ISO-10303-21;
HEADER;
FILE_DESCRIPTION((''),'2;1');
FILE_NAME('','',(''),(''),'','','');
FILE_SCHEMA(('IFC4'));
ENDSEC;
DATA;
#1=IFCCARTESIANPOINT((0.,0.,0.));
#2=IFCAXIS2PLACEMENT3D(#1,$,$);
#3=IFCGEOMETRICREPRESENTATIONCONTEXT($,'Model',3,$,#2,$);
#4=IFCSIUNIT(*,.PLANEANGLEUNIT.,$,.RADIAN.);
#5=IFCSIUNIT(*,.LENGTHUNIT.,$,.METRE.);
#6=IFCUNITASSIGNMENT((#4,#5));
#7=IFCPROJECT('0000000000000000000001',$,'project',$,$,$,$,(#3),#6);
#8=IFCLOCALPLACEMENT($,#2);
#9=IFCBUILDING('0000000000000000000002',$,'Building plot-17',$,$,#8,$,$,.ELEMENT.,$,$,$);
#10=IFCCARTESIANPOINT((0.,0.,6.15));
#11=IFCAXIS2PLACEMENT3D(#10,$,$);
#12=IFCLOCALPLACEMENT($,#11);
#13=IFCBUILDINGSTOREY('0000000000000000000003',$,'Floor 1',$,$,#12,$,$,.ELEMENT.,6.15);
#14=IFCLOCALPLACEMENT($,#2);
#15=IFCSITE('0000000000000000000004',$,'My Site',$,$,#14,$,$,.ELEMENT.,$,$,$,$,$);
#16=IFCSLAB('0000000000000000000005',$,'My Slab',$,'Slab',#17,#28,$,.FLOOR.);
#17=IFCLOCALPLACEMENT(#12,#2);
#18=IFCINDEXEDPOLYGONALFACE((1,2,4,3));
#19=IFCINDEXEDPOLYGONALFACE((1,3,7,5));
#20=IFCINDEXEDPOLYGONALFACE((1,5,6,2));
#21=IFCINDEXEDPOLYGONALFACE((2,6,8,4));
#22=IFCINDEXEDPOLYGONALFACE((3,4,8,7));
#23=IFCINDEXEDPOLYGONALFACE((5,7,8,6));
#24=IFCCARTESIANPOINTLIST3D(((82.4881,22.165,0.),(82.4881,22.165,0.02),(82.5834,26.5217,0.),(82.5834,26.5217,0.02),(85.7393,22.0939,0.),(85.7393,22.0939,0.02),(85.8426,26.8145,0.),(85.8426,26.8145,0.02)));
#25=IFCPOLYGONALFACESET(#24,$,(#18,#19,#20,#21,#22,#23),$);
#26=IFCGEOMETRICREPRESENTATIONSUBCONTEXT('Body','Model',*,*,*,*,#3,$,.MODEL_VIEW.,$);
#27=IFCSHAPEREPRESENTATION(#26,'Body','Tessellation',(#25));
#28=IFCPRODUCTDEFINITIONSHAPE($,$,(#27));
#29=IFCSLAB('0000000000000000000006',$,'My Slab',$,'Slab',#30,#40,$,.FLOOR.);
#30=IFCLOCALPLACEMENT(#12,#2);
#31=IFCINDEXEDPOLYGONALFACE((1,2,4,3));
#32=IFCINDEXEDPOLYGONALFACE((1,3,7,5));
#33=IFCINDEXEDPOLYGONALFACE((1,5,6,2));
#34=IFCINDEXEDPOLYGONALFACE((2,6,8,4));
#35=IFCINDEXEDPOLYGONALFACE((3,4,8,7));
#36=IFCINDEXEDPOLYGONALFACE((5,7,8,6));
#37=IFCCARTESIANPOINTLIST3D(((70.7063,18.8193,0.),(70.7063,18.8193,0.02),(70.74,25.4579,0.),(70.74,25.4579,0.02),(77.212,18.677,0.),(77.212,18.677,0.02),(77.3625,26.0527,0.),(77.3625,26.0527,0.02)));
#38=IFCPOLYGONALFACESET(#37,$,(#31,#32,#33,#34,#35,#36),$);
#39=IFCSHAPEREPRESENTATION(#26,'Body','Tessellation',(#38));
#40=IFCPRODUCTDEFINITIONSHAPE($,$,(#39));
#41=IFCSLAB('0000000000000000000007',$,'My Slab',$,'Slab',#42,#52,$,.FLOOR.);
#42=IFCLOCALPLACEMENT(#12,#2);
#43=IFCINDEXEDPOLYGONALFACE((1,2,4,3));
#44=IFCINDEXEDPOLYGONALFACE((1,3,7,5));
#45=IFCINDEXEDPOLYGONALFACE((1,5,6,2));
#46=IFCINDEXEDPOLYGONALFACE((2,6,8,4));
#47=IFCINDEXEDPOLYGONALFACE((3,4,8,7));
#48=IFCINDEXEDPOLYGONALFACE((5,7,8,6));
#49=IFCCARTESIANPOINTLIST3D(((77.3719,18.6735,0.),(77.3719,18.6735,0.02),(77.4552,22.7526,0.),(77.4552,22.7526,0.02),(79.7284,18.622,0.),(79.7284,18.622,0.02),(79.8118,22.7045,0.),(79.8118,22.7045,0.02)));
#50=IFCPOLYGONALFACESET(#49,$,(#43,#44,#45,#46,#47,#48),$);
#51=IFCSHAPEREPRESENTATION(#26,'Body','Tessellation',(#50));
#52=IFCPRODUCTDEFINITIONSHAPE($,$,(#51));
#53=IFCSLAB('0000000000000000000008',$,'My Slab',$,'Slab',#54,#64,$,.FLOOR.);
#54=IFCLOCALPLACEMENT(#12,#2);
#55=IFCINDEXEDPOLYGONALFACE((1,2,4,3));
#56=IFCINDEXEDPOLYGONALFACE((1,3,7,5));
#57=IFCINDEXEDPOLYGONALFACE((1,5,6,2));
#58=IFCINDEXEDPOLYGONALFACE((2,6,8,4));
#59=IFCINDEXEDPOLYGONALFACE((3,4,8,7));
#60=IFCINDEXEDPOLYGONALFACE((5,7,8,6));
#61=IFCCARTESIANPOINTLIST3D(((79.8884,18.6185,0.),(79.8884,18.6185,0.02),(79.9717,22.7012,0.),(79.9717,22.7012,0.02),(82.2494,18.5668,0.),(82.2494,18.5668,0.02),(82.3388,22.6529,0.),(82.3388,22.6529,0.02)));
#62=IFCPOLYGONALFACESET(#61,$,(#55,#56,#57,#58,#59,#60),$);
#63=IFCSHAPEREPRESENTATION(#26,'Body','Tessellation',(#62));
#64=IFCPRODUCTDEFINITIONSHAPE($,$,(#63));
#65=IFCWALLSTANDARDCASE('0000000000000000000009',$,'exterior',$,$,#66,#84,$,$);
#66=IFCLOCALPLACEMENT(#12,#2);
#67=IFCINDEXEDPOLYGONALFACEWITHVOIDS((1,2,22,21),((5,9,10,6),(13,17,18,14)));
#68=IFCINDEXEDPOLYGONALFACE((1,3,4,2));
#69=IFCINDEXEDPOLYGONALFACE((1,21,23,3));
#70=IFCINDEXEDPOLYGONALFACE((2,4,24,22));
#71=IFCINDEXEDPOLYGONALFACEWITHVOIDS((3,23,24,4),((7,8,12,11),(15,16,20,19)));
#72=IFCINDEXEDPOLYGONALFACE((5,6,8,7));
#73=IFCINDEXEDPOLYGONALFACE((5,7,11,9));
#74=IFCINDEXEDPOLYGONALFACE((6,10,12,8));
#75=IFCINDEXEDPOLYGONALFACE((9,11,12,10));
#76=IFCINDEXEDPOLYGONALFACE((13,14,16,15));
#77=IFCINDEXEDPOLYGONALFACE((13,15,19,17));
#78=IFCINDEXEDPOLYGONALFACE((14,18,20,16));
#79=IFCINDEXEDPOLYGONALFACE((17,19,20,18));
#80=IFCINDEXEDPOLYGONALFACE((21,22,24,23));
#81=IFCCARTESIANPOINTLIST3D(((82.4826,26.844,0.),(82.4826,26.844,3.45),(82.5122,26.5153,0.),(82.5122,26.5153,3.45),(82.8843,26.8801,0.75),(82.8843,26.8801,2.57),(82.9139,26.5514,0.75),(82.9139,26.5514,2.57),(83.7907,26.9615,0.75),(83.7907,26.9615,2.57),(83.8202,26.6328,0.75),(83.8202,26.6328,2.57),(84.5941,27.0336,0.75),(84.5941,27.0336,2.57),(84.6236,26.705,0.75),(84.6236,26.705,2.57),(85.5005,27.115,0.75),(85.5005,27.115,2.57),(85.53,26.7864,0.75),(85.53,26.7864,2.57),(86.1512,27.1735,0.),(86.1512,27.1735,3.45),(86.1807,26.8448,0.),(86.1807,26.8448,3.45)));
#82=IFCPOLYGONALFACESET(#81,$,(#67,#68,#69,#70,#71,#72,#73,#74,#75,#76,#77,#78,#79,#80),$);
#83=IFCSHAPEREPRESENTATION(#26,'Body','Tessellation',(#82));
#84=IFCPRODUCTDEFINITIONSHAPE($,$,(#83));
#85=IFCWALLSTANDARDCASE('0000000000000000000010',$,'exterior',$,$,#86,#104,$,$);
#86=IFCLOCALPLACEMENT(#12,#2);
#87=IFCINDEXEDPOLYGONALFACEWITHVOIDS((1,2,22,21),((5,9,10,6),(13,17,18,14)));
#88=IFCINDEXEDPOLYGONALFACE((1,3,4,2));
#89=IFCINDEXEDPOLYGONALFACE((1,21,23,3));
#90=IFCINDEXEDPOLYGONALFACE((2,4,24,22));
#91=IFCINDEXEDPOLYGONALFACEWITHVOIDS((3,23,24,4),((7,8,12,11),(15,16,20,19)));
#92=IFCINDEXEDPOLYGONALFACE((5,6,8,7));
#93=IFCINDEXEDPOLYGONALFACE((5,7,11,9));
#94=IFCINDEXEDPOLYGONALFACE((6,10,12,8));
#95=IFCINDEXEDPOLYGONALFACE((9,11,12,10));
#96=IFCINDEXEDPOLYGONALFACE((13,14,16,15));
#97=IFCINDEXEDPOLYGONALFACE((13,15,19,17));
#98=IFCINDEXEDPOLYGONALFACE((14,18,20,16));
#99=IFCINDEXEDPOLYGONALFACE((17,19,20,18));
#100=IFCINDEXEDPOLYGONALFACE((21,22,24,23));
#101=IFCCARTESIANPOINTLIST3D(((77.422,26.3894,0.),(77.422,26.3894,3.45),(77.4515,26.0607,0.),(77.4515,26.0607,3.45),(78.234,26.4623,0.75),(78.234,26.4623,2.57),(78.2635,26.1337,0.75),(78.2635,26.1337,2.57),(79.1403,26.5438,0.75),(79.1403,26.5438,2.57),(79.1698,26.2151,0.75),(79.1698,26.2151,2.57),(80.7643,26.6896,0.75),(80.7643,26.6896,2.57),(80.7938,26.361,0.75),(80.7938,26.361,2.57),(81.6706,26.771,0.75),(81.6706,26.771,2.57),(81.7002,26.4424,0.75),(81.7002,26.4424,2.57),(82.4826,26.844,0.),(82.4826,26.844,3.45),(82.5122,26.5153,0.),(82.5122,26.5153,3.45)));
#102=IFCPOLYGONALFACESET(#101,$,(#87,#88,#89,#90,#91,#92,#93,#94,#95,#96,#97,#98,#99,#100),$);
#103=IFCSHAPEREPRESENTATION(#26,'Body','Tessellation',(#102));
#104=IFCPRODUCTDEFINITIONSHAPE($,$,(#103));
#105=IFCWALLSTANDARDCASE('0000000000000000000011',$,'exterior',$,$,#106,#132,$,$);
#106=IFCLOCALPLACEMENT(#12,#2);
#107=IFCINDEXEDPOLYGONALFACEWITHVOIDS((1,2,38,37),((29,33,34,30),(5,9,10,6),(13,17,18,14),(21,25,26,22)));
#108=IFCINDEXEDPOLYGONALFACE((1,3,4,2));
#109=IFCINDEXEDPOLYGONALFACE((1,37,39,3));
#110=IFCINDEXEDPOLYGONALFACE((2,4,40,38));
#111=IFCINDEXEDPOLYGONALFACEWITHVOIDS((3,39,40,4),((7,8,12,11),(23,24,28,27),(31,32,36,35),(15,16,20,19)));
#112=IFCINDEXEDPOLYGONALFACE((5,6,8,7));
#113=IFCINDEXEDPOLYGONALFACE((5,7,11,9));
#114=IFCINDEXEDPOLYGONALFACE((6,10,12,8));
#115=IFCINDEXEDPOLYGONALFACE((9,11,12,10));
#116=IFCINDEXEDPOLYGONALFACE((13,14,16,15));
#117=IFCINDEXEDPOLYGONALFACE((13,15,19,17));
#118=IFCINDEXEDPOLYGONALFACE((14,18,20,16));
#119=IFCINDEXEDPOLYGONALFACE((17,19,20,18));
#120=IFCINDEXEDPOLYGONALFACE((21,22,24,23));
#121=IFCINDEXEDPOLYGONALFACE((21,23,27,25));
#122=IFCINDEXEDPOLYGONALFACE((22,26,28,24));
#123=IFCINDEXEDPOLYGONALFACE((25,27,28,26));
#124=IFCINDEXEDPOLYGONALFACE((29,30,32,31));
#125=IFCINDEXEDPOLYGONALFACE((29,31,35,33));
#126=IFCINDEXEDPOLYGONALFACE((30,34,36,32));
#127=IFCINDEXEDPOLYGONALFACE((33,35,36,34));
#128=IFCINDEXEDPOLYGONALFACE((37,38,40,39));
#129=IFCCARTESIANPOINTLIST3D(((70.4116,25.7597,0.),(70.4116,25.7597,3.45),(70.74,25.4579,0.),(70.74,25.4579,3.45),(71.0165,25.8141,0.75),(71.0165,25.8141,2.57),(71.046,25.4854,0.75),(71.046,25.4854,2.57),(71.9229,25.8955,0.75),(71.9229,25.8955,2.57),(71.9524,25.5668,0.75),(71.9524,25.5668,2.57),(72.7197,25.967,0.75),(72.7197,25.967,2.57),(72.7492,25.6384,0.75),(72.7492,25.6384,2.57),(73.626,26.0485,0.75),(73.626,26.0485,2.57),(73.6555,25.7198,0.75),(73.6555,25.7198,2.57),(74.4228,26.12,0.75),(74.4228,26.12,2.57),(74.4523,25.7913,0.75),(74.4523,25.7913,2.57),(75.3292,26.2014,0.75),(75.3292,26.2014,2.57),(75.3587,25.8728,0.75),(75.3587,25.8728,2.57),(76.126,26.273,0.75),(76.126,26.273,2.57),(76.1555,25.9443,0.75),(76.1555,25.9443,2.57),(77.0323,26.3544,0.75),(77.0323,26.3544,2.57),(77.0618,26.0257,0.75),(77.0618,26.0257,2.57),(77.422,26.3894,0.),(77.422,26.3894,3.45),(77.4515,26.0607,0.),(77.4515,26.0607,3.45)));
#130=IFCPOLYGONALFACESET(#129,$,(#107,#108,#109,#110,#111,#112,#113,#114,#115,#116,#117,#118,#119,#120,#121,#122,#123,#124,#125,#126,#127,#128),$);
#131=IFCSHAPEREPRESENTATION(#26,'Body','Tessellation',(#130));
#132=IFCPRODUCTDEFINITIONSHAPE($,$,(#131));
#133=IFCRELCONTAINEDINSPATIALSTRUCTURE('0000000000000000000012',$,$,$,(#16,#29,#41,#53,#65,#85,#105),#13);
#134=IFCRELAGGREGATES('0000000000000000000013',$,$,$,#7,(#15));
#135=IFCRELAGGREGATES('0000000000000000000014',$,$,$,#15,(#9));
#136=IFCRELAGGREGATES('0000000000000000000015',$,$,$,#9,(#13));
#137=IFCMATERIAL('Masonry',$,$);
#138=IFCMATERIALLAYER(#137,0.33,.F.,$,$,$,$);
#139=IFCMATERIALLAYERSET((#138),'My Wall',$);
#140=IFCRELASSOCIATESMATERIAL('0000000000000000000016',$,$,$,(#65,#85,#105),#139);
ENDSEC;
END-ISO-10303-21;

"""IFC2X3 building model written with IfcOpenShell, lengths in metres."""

from ifc_helpers import new_model, si_unit, frame, origin, place, context, subcontext, project, spatial, polyline, outline, extrude, material, layer, layer_set, layer_usage, element, save


model = new_model("IFC2X3")

# Units and contexts
model_context = context("Model", 3, world=origin())
body_context = subcontext(model_context, "Body", "Model", "MODEL_VIEW")
ifc_project = project(units=[si_unit("PLANEANGLEUNIT", "RADIAN"), si_unit("LENGTHUNIT", "METRE")], contexts=[model_context])

# Site, building, storey
site_placement = place(None, origin())
site = spatial("IfcSite", under=ifc_project, at=site_placement, Name="My Site", CompositionType="ELEMENT")
building_placement = place(None, origin())
building = spatial("IfcBuilding", under=site, at=building_placement, Name="Building plot-17", CompositionType="ELEMENT")
storey_placement = place(None, frame((0.0, 0.0, 6.15)))
storey = spatial("IfcBuildingStorey", under=building, at=storey_placement, Name="Floor 1", CompositionType="ELEMENT", Elevation=6.15)

# Slabs
slab_1_placement = place(storey_placement, origin())
element("IfcSlab", 1, at=slab_1_placement, inside=storey, Name="My Slab", ObjectType="Slab", PredefinedType="FLOOR", context=body_context, shape_type="SweptSolid", body=[
    extrude(outline(polyline([(85.7393, 22.0939), (85.8426, 26.8145), (82.5834, 26.5217), (82.4881, 22.165), (85.7393, 22.0939)])), origin(), (0.0, 0.0, 1.0), 0.02),
])
slab_2_placement = place(storey_placement, origin())
element("IfcSlab", 2, at=slab_2_placement, inside=storey, Name="My Slab", ObjectType="Slab", PredefinedType="FLOOR", context=body_context, shape_type="SweptSolid", body=[
    extrude(outline(polyline([(77.3625, 26.0527), (70.74, 25.4579), (70.7063, 18.8193), (77.212, 18.677), (77.3625, 26.0527)])), origin(), (0.0, 0.0, 1.0), 0.02),
])
slab_3_placement = place(storey_placement, origin())
element("IfcSlab", 3, at=slab_3_placement, inside=storey, Name="My Slab", ObjectType="Slab", PredefinedType="FLOOR", context=body_context, shape_type="SweptSolid", body=[
    extrude(outline(polyline([(77.3719, 18.6735), (79.7284, 18.622), (79.8118, 22.7045), (77.4552, 22.7526), (77.3719, 18.6735)])), origin(), (0.0, 0.0, 1.0), 0.02),
])
slab_4_placement = place(storey_placement, origin())
element("IfcSlab", 4, at=slab_4_placement, inside=storey, Name="My Slab", ObjectType="Slab", PredefinedType="FLOOR", context=body_context, shape_type="SweptSolid", body=[
    extrude(outline(polyline([(79.8884, 18.6185), (82.2494, 18.5668), (82.3388, 22.6529), (79.9717, 22.7012), (79.8884, 18.6185)])), origin(), (0.0, 0.0, 1.0), 0.02),
])

# Walls, openings
ifc_material = material(Name="Masonry")
ifc_layer = layer(ifc_material, 0.33, ventilated=False)
ifc_layer_set = layer_set([ifc_layer], Name="My Wall")
ifc_layer_usage = layer_usage(ifc_layer_set, "AXIS2", "NEGATIVE", 0.08)
wall_1_placement = place(storey_placement, origin())
wall_1 = element("IfcWallStandardCase", 5, at=wall_1_placement, inside=storey, material=ifc_layer_usage, Name="exterior", context=body_context, shape_type="SweptSolid", body=[
    extrude(outline(polyline([(86.1807, 26.8448), (86.1512, 27.1735), (82.4826, 26.844), (82.5122, 26.5153), (86.1807, 26.8448)])), origin(), (0.0, 0.0, 1.0), 3.45),
])
opening_1_placement = place(storey_placement, frame((0.0, 0.0, 0.75)))
element("IfcOpeningElement", 6, at=opening_1_placement, cuts=wall_1, ObjectType="Opening", context=body_context, shape_type="SweptSolid", body=[
    extrude(outline(polyline([(85.5005, 27.115), (84.5941, 27.0336), (84.6236, 26.705), (85.53, 26.7864), (85.5005, 27.115)])), origin(), (0.0, 0.0, 1.0), 1.82),
])
opening_2_placement = place(storey_placement, frame((0.0, 0.0, 0.75)))
element("IfcOpeningElement", 7, at=opening_2_placement, cuts=wall_1, ObjectType="Opening", context=body_context, shape_type="SweptSolid", body=[
    extrude(outline(polyline([(83.7907, 26.9615), (82.8843, 26.8801), (82.9139, 26.5514), (83.8202, 26.6328), (83.7907, 26.9615)])), origin(), (0.0, 0.0, 1.0), 1.82),
])
wall_2_placement = place(storey_placement, origin())
wall_2 = element("IfcWallStandardCase", 8, at=wall_2_placement, inside=storey, material=ifc_layer_usage, Name="exterior", context=body_context, shape_type="SweptSolid", body=[
    extrude(outline(polyline([(82.5122, 26.5153), (82.4826, 26.844), (77.422, 26.3894), (77.4515, 26.0607), (82.5122, 26.5153)])), origin(), (0.0, 0.0, 1.0), 3.45),
])
opening_3_placement = place(storey_placement, frame((0.0, 0.0, 0.75)))
element("IfcOpeningElement", 9, at=opening_3_placement, cuts=wall_2, ObjectType="Opening", context=body_context, shape_type="SweptSolid", body=[
    extrude(outline(polyline([(81.6706, 26.771), (80.7643, 26.6896), (80.7938, 26.361), (81.7002, 26.4424), (81.6706, 26.771)])), origin(), (0.0, 0.0, 1.0), 1.82),
])
opening_4_placement = place(storey_placement, frame((0.0, 0.0, 0.75)))
element("IfcOpeningElement", 10, at=opening_4_placement, cuts=wall_2, ObjectType="Opening", context=body_context, shape_type="SweptSolid", body=[
    extrude(outline(polyline([(79.1403, 26.5438), (78.234, 26.4623), (78.2635, 26.1337), (79.1698, 26.2151), (79.1403, 26.5438)])), origin(), (0.0, 0.0, 1.0), 1.82),
])
wall_3_placement = place(storey_placement, origin())
wall_3 = element("IfcWallStandardCase", 11, at=wall_3_placement, inside=storey, material=ifc_layer_usage, Name="exterior", context=body_context, shape_type="SweptSolid", body=[
    extrude(outline(polyline([(77.4515, 26.0607), (77.422, 26.3894), (70.4116, 25.7597), (70.74, 25.4579), (77.4515, 26.0607)])), origin(), (0.0, 0.0, 1.0), 3.45),
])
opening_5_placement = place(storey_placement, frame((0.0, 0.0, 0.75)))
element("IfcOpeningElement", 12, at=opening_5_placement, cuts=wall_3, ObjectType="Opening", context=body_context, shape_type="SweptSolid", body=[
    extrude(outline(polyline([(77.0323, 26.3544), (76.126, 26.273), (76.1555, 25.9443), (77.0618, 26.0257), (77.0323, 26.3544)])), origin(), (0.0, 0.0, 1.0), 1.82),
])
opening_6_placement = place(storey_placement, frame((0.0, 0.0, 0.75)))
element("IfcOpeningElement", 13, at=opening_6_placement, cuts=wall_3, ObjectType="Opening", context=body_context, shape_type="SweptSolid", body=[
    extrude(outline(polyline([(75.3292, 26.2014), (74.4228, 26.12), (74.4523, 25.7913), (75.3587, 25.8728), (75.3292, 26.2014)])), origin(), (0.0, 0.0, 1.0), 1.82),
])
opening_7_placement = place(storey_placement, frame((0.0, 0.0, 0.75)))
element("IfcOpeningElement", 14, at=opening_7_placement, cuts=wall_3, ObjectType="Opening", context=body_context, shape_type="SweptSolid", body=[
    extrude(outline(polyline([(73.626, 26.0485), (72.7197, 25.967), (72.7492, 25.6384), (73.6555, 25.7198), (73.626, 26.0485)])), origin(), (0.0, 0.0, 1.0), 1.82),
])
opening_8_placement = place(storey_placement, frame((0.0, 0.0, 0.75)))
element("IfcOpeningElement", 15, at=opening_8_placement, cuts=wall_3, ObjectType="Opening", context=body_context, shape_type="SweptSolid", body=[
    extrude(outline(polyline([(71.9229, 25.8955), (71.0165, 25.8141), (71.046, 25.4854), (71.9524, 25.5668), (71.9229, 25.8955)])), origin(), (0.0, 0.0, 1.0), 1.82),
])

save(model, "model.ifc")
